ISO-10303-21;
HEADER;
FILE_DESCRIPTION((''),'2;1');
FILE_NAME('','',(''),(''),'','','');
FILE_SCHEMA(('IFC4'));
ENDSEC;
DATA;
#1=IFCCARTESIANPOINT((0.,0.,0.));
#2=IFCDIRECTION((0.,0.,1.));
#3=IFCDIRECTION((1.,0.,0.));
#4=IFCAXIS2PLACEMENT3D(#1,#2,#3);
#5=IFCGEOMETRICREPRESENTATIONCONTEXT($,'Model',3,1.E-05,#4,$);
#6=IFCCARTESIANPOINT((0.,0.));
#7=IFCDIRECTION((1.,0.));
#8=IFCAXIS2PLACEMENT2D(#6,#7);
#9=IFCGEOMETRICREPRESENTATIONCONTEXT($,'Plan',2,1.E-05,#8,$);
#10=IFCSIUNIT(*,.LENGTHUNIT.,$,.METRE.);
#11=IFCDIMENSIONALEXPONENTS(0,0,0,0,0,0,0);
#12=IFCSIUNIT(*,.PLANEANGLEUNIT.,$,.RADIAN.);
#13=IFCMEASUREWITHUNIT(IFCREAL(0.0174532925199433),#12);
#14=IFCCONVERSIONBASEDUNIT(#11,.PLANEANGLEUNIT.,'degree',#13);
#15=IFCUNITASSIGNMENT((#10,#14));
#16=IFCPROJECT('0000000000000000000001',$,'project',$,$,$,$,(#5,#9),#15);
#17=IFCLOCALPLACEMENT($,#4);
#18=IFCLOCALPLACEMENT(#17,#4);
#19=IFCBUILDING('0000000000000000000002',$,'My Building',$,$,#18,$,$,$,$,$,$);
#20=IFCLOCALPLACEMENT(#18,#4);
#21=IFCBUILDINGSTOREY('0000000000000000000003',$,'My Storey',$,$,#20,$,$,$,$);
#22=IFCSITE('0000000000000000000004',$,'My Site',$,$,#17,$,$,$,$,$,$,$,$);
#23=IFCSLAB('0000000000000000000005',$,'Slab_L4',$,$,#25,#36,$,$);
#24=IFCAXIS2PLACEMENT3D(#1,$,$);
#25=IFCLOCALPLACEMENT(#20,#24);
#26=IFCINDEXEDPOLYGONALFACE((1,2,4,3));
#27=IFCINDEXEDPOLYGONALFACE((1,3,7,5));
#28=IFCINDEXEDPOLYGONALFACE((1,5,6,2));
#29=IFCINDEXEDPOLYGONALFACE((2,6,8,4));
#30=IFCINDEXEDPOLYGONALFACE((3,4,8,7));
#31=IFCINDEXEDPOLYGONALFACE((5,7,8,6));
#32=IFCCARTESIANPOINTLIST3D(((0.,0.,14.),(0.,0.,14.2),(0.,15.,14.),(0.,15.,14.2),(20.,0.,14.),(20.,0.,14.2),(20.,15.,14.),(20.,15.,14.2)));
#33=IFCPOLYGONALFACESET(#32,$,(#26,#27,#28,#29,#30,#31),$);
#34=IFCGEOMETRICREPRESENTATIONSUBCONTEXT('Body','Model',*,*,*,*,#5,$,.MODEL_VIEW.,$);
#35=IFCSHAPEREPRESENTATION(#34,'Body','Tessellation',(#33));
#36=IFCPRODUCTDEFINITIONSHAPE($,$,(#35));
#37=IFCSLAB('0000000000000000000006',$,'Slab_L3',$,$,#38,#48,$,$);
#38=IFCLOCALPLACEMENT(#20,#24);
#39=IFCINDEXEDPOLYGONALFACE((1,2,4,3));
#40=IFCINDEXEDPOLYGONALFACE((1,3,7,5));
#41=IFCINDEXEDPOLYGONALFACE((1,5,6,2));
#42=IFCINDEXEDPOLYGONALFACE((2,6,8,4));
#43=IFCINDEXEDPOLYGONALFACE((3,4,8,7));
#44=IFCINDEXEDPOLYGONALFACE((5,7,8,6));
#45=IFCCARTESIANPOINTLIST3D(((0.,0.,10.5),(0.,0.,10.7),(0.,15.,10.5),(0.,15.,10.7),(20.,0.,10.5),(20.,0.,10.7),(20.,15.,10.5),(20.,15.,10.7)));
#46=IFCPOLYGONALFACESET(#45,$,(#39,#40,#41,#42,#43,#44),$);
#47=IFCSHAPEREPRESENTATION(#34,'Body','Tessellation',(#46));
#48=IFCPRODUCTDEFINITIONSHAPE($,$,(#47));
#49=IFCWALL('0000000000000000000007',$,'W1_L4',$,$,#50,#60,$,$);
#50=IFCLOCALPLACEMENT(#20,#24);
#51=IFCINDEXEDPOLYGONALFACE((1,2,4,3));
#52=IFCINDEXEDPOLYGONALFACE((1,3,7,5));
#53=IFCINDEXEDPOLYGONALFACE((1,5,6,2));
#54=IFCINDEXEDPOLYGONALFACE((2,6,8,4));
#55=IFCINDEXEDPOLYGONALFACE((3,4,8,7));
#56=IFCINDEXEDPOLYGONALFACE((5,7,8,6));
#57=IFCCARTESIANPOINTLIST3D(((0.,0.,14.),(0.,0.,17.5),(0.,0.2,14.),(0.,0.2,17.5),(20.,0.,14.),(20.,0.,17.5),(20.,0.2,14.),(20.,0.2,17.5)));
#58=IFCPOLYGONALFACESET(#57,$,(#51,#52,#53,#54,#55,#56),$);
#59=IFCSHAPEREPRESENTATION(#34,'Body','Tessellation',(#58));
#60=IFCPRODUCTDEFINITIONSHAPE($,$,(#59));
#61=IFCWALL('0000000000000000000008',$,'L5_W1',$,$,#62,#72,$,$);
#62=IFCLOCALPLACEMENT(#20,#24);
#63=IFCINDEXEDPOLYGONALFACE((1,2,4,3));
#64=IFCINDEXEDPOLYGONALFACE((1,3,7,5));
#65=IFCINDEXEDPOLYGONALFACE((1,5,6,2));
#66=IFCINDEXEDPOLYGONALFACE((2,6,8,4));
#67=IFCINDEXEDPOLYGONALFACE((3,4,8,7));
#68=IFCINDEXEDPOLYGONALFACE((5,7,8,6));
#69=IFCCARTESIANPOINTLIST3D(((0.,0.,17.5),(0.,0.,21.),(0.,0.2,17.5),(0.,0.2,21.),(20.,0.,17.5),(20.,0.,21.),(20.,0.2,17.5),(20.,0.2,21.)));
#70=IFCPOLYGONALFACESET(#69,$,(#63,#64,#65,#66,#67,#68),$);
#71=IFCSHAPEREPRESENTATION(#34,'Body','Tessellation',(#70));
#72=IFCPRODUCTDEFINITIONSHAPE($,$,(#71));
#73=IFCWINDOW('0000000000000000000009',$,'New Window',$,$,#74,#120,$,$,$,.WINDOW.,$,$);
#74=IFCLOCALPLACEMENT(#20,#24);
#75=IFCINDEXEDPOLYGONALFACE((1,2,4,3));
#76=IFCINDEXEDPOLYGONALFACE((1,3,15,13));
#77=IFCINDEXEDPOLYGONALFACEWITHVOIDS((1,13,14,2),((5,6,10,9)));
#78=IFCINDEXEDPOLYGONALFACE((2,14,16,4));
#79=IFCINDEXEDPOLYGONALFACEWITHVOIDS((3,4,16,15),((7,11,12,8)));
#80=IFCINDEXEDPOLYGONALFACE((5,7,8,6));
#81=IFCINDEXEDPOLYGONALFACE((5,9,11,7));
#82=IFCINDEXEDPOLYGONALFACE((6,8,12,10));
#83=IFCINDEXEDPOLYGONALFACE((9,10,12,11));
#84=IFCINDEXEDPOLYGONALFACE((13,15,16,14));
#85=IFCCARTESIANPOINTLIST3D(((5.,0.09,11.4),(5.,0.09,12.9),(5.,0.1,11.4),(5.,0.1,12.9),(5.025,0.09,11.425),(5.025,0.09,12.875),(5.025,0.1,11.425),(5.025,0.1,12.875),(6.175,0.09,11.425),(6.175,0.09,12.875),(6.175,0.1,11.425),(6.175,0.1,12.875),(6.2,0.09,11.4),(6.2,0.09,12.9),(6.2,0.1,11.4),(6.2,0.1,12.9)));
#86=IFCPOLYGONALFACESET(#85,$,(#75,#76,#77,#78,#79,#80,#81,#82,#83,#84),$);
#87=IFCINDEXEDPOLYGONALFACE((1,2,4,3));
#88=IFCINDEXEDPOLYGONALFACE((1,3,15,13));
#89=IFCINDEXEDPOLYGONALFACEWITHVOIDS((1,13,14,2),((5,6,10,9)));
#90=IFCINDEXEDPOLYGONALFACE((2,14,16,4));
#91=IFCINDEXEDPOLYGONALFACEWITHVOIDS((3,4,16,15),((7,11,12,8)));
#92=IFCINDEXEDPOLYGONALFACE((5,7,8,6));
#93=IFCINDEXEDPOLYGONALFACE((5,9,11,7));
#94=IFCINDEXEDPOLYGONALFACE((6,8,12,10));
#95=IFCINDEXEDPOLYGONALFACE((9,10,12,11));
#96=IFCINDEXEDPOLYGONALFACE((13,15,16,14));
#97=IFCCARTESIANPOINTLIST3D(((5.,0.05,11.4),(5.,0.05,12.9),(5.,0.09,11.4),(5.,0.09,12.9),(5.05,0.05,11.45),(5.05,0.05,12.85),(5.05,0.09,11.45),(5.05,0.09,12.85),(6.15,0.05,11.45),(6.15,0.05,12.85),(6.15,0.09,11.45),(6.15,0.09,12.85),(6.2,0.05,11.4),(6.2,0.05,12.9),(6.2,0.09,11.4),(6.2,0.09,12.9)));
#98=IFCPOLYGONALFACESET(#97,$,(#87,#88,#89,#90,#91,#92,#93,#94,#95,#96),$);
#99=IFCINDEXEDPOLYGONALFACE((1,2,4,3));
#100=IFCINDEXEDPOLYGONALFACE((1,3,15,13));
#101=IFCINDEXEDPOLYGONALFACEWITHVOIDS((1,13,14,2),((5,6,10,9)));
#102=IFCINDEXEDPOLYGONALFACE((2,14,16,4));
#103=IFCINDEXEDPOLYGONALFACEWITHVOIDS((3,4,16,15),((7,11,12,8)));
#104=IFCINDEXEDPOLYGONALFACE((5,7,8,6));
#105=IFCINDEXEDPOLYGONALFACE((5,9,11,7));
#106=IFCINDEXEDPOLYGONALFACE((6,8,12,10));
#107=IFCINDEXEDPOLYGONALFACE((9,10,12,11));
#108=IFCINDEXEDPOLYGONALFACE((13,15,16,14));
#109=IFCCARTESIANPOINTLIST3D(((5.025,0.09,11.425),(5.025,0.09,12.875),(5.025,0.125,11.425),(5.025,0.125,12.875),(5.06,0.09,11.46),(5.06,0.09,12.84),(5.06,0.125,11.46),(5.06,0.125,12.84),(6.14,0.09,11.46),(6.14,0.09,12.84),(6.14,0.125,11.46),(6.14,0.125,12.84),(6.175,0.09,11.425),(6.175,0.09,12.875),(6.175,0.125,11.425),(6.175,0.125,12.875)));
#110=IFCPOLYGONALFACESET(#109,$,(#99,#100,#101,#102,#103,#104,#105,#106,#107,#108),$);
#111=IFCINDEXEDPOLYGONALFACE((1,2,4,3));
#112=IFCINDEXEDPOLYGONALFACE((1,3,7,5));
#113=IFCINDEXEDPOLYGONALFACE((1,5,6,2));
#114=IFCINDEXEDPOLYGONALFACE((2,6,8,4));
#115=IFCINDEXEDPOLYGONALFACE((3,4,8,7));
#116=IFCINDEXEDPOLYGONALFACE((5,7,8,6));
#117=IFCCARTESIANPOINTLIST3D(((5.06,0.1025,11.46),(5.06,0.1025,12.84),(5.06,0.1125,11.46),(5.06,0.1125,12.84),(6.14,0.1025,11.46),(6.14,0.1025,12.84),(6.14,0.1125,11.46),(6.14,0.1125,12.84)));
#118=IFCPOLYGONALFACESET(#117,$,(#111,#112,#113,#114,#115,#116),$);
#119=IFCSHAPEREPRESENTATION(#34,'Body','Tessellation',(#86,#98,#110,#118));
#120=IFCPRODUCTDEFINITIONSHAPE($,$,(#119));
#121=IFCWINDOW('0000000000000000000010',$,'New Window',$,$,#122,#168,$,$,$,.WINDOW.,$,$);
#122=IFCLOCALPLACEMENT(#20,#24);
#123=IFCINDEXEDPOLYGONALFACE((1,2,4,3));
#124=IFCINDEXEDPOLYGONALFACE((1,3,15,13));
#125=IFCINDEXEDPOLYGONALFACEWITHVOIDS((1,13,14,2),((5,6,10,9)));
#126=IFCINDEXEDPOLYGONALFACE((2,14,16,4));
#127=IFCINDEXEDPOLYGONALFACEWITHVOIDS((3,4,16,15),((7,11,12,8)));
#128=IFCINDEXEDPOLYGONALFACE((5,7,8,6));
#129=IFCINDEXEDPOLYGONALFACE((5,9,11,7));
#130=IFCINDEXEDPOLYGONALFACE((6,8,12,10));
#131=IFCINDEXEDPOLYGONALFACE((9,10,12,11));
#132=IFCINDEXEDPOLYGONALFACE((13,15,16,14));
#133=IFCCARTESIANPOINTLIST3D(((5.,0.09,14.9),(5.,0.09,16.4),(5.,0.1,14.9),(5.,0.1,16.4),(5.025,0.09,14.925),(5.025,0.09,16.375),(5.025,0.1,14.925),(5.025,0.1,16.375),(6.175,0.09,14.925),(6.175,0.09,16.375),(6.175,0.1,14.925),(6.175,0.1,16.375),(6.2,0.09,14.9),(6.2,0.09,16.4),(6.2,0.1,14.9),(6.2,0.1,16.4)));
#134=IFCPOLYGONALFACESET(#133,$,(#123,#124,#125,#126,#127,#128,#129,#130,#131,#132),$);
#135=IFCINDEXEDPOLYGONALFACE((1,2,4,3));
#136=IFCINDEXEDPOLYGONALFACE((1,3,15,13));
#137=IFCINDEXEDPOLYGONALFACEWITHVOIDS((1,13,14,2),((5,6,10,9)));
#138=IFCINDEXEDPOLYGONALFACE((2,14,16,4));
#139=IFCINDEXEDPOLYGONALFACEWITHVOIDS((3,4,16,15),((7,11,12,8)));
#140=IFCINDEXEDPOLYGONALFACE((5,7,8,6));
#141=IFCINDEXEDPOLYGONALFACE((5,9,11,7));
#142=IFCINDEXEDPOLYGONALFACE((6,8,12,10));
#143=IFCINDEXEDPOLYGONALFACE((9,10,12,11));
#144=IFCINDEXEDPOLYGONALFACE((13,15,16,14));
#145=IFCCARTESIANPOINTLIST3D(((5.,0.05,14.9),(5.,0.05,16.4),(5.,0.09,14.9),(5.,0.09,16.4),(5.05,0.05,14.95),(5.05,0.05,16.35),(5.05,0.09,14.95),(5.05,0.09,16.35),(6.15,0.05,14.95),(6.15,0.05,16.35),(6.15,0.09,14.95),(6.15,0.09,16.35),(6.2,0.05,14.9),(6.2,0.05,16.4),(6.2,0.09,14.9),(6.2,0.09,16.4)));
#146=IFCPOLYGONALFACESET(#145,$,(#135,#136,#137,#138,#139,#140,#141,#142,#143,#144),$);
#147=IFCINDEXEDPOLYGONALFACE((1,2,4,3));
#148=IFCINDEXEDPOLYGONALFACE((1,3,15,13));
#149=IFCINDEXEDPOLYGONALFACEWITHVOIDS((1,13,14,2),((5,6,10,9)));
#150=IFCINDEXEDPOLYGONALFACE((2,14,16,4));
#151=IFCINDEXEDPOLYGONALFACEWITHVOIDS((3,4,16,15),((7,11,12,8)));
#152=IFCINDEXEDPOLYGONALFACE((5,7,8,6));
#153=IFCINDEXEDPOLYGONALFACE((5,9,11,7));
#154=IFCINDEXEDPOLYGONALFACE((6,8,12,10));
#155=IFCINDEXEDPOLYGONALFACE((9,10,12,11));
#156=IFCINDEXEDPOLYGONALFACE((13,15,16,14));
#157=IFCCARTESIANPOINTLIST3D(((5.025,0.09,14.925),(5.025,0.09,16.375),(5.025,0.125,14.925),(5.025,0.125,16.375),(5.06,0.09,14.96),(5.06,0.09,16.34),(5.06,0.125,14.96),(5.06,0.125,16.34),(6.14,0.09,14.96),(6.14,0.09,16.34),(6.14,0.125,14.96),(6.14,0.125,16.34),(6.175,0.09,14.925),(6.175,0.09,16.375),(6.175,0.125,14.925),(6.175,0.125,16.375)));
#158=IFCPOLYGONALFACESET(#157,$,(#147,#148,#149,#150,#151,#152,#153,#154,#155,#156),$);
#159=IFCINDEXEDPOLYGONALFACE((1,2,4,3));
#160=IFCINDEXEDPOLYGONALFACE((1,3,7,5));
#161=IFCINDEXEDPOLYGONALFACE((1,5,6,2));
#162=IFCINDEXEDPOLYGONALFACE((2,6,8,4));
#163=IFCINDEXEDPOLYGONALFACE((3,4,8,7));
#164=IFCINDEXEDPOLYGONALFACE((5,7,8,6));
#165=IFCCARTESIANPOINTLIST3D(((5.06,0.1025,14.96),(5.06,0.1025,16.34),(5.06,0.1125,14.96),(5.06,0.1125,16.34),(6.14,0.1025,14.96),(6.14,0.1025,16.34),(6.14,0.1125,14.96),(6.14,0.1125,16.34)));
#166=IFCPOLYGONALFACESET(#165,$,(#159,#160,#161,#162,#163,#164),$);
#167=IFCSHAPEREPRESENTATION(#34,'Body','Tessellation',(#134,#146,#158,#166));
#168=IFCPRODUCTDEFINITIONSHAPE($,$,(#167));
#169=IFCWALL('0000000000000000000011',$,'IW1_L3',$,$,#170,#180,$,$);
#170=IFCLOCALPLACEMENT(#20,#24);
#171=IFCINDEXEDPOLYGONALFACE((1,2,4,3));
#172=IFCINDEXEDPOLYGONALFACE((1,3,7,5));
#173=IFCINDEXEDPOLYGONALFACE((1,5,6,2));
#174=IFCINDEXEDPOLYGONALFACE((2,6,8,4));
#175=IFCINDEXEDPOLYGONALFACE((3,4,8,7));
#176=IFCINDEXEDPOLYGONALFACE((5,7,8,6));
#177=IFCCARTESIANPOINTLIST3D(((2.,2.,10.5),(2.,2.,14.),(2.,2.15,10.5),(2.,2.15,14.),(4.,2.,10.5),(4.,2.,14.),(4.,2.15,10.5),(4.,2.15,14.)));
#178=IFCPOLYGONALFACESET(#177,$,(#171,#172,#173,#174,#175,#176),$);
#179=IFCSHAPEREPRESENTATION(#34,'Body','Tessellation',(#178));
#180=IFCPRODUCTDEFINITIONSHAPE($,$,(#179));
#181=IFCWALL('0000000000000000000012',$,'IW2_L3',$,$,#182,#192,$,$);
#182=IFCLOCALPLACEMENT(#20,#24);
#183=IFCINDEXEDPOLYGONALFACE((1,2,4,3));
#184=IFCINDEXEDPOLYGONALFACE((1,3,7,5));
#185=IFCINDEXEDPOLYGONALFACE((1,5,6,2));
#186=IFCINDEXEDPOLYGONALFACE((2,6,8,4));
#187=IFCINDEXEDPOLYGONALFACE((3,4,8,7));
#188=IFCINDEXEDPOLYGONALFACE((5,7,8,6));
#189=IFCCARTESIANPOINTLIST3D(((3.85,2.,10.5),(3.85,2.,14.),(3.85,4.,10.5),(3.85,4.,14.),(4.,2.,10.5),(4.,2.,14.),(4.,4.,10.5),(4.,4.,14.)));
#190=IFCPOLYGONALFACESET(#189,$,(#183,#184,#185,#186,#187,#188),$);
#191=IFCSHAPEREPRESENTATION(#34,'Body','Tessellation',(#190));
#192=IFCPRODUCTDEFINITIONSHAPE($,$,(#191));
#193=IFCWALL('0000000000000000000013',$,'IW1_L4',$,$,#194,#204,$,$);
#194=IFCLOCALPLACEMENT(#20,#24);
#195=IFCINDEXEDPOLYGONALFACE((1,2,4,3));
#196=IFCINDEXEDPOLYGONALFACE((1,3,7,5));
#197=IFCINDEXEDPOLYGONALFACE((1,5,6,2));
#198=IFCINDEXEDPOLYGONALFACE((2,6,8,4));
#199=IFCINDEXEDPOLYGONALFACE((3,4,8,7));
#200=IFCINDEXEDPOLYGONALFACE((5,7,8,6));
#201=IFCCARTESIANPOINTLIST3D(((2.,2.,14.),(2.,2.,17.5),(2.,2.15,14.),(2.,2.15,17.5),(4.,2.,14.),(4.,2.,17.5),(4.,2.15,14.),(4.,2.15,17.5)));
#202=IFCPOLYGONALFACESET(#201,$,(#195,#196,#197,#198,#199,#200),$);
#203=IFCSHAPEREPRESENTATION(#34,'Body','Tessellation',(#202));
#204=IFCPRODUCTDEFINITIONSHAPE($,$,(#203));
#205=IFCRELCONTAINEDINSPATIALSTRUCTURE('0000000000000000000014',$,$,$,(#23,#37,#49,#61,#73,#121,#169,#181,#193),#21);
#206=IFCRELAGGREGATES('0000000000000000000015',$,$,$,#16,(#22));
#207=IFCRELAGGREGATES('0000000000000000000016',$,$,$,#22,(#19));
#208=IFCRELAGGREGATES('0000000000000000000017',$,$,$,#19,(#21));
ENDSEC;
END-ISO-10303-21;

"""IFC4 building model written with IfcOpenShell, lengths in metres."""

from ifc_helpers import new_model, entity, si_unit, converted_unit, frame, origin_with_axes, origin_2d_with_axis, place, context, subcontext, project, spatial, line, indexed_curve, outline, extrude, element, save


model = new_model("IFC4")

# Units and contexts
model_context = context("Model", 3, precision=1e-05, world=origin_with_axes())
plan_context = context("Plan", 2, precision=1e-05, world=origin_2d_with_axis())
body_context = subcontext(model_context, "Body", "Model", "MODEL_VIEW")
ifc_project = project(units=[si_unit("LENGTHUNIT", "METRE"), converted_unit("PLANEANGLEUNIT", "degree", entity("IfcReal", 0.0174532925199433), si_unit("PLANEANGLEUNIT", "RADIAN"), dimensions=[0, 0, 0, 0, 0, 0, 0])], contexts=[model_context, plan_context])

# Site, building, storey
site_placement = place(None, origin_with_axes())
site = spatial("IfcSite", under=ifc_project, at=site_placement, Name="My Site")
building_placement = place(site_placement, origin_with_axes())
building = spatial("IfcBuilding", under=site, at=building_placement, Name="My Building")
storey_placement = place(building_placement, origin_with_axes())
storey = spatial("IfcBuildingStorey", under=building, at=storey_placement, Name="My Storey")

# Slabs
for number, where, z_axis, x_axis, name in (
    (1, (0.0, 0.0, 14.0), (0.0, 0.0, 1.0), (1.0, 0.0, 0.0), "Slab_L4"),
    (2, (0.0, 0.0, 10.5), (0.0, 0.0, 1.0), (1.0, 0.0, 0.0), "Slab_L3"),
):
    element("IfcSlab", number, at=place(storey_placement, frame(where, z_axis=z_axis, x_axis=x_axis)), inside=storey, Name=name, context=body_context, shape_type="SweptSolid", body=[
        extrude(outline(indexed_curve([(0.0, 0.0), (20.0, 0.0), (20.0, 15.0), (0.0, 15.0), (0.0, 0.0)])), None, (0.0, 0.0, 1.0), 0.2),
    ])

# Walls
for number, where, z_axis, x_axis, name in (
    (3, (0.0, 0.0, 14.0), (0.0, 0.0, 1.0), (1.0, 0.0, 0.0), "W1_L4"),
    (4, (0.0, 0.0, 17.5), (0.0, 0.0, 1.0), (1.0, 0.0, 0.0), "L5_W1"),
):
    element("IfcWall", number, at=place(storey_placement, frame(where, z_axis=z_axis, x_axis=x_axis)), inside=storey, Name=name, context=body_context, shape_type="SweptSolid", body=[
        extrude(outline(indexed_curve([(0.0, 0.0), (0.0, 0.2), (20.0, 0.2), (20.0, 0.0), (0.0, 0.0)], self_intersect=False)), origin_with_axes(), (0.0, 0.0, 1.0), 3.5),
    ])

# Windows
for number, where, z_axis, x_axis, name in (
    (5, (5.0, 0.0, 11.4), (0.0, 0.0, 1.0), (1.0, 0.0, 0.0), "New Window"),
    (6, (5.0, 0.0, 14.9), (0.0, 0.0, 1.0), (1.0, 0.0, 0.0), "New Window"),
):
    element("IfcWindow", number, at=place(storey_placement, frame(where, z_axis=z_axis, x_axis=x_axis)), inside=storey, Name=name, PredefinedType="WINDOW", context=body_context, shape_type="SweptSolid", body=[
        extrude(outline(indexed_curve([(0.0, 0.0), (1.2, 0.0), (1.2, 1.5), (0.0, 1.5)], segments=[line(1, 2, 3, 4, 1)]), holes=[indexed_curve([(0.025, 0.025), (1.175, 0.025), (1.175, 1.475), (0.025, 1.475)], segments=[line(1, 2, 3, 4, 1)])]), frame((0.0, 0.09, 0.0), z_axis=(0.0, -1.0, 0.0), x_axis=(1.0, 0.0, 0.0)), (0.0, 0.0, -1.0), 0.01),
        extrude(outline(indexed_curve([(0.0, 0.0), (1.2, 0.0), (1.2, 1.5), (0.0, 1.5)], segments=[line(1, 2, 3, 4, 1)]), holes=[indexed_curve([(0.05, 0.05), (1.15, 0.05), (1.15, 1.45), (0.05, 1.45)], segments=[line(1, 2, 3, 4, 1)])]), frame((0.0, 0.05, 0.0), z_axis=(0.0, -1.0, 0.0), x_axis=(1.0, 0.0, 0.0)), (0.0, 0.0, -1.0), 0.04),
        extrude(outline(indexed_curve([(0.0, 0.0), (1.15, 0.0), (1.15, 1.45), (0.0, 1.45)], segments=[line(1, 2, 3, 4, 1)]), holes=[indexed_curve([(0.035, 0.035), (1.115, 0.035), (1.115, 1.415), (0.035, 1.415)], segments=[line(1, 2, 3, 4, 1)])]), frame((0.025, 0.09, 0.025), z_axis=(0.0, -1.0, 0.0), x_axis=(1.0, 0.0, 0.0)), (0.0, 0.0, -1.0), 0.035),
        extrude(outline(indexed_curve([(0.035, 0.035), (1.115, 0.035), (1.115, 1.415), (0.035, 1.415)], segments=[line(1, 2, 3, 4, 1)])), frame((0.025, 0.1025, 0.025), z_axis=(0.0, -1.0, 0.0), x_axis=(1.0, 0.0, 0.0)), (0.0, 0.0, -1.0), 0.01),
    ])

# Walls
for number, where, z_axis, x_axis, name in (
    (7, (2.0, 2.0, 10.5), (0.0, 0.0, 1.0), (1.0, 0.0, 0.0), "IW1_L3"),
    (8, (4.0, 2.0, 10.5), (0.0, 0.0, 1.0), (0.0, 1.0, 0.0), "IW2_L3"),
):
    element("IfcWall", number, at=place(storey_placement, frame(where, z_axis=z_axis, x_axis=x_axis)), inside=storey, Name=name, context=body_context, shape_type="SweptSolid", body=[
        extrude(outline(indexed_curve([(0.0, 0.0), (0.0, 0.15), (2.0, 0.15), (2.0, 0.0), (0.0, 0.0)], self_intersect=False)), origin_with_axes(), (0.0, 0.0, 1.0), 3.5),
    ])
wall_1_placement = place(storey_placement, frame((2.0, 2.0, 14.0), z_axis=(0.0, 0.0, 1.0), x_axis=(1.0, 0.0, 0.0)))
element("IfcWall", 9, at=wall_1_placement, inside=storey, Name="IW1_L4", context=body_context, shape_type="SweptSolid", body=[
    extrude(outline(indexed_curve([(0.0, 0.0), (0.0, 0.15), (2.0, 0.15), (2.0, 0.0), (0.0, 0.0)], self_intersect=False)), origin_with_axes(), (0.0, 0.0, 1.0), 3.5),
])

save(model, "model.ifc")
